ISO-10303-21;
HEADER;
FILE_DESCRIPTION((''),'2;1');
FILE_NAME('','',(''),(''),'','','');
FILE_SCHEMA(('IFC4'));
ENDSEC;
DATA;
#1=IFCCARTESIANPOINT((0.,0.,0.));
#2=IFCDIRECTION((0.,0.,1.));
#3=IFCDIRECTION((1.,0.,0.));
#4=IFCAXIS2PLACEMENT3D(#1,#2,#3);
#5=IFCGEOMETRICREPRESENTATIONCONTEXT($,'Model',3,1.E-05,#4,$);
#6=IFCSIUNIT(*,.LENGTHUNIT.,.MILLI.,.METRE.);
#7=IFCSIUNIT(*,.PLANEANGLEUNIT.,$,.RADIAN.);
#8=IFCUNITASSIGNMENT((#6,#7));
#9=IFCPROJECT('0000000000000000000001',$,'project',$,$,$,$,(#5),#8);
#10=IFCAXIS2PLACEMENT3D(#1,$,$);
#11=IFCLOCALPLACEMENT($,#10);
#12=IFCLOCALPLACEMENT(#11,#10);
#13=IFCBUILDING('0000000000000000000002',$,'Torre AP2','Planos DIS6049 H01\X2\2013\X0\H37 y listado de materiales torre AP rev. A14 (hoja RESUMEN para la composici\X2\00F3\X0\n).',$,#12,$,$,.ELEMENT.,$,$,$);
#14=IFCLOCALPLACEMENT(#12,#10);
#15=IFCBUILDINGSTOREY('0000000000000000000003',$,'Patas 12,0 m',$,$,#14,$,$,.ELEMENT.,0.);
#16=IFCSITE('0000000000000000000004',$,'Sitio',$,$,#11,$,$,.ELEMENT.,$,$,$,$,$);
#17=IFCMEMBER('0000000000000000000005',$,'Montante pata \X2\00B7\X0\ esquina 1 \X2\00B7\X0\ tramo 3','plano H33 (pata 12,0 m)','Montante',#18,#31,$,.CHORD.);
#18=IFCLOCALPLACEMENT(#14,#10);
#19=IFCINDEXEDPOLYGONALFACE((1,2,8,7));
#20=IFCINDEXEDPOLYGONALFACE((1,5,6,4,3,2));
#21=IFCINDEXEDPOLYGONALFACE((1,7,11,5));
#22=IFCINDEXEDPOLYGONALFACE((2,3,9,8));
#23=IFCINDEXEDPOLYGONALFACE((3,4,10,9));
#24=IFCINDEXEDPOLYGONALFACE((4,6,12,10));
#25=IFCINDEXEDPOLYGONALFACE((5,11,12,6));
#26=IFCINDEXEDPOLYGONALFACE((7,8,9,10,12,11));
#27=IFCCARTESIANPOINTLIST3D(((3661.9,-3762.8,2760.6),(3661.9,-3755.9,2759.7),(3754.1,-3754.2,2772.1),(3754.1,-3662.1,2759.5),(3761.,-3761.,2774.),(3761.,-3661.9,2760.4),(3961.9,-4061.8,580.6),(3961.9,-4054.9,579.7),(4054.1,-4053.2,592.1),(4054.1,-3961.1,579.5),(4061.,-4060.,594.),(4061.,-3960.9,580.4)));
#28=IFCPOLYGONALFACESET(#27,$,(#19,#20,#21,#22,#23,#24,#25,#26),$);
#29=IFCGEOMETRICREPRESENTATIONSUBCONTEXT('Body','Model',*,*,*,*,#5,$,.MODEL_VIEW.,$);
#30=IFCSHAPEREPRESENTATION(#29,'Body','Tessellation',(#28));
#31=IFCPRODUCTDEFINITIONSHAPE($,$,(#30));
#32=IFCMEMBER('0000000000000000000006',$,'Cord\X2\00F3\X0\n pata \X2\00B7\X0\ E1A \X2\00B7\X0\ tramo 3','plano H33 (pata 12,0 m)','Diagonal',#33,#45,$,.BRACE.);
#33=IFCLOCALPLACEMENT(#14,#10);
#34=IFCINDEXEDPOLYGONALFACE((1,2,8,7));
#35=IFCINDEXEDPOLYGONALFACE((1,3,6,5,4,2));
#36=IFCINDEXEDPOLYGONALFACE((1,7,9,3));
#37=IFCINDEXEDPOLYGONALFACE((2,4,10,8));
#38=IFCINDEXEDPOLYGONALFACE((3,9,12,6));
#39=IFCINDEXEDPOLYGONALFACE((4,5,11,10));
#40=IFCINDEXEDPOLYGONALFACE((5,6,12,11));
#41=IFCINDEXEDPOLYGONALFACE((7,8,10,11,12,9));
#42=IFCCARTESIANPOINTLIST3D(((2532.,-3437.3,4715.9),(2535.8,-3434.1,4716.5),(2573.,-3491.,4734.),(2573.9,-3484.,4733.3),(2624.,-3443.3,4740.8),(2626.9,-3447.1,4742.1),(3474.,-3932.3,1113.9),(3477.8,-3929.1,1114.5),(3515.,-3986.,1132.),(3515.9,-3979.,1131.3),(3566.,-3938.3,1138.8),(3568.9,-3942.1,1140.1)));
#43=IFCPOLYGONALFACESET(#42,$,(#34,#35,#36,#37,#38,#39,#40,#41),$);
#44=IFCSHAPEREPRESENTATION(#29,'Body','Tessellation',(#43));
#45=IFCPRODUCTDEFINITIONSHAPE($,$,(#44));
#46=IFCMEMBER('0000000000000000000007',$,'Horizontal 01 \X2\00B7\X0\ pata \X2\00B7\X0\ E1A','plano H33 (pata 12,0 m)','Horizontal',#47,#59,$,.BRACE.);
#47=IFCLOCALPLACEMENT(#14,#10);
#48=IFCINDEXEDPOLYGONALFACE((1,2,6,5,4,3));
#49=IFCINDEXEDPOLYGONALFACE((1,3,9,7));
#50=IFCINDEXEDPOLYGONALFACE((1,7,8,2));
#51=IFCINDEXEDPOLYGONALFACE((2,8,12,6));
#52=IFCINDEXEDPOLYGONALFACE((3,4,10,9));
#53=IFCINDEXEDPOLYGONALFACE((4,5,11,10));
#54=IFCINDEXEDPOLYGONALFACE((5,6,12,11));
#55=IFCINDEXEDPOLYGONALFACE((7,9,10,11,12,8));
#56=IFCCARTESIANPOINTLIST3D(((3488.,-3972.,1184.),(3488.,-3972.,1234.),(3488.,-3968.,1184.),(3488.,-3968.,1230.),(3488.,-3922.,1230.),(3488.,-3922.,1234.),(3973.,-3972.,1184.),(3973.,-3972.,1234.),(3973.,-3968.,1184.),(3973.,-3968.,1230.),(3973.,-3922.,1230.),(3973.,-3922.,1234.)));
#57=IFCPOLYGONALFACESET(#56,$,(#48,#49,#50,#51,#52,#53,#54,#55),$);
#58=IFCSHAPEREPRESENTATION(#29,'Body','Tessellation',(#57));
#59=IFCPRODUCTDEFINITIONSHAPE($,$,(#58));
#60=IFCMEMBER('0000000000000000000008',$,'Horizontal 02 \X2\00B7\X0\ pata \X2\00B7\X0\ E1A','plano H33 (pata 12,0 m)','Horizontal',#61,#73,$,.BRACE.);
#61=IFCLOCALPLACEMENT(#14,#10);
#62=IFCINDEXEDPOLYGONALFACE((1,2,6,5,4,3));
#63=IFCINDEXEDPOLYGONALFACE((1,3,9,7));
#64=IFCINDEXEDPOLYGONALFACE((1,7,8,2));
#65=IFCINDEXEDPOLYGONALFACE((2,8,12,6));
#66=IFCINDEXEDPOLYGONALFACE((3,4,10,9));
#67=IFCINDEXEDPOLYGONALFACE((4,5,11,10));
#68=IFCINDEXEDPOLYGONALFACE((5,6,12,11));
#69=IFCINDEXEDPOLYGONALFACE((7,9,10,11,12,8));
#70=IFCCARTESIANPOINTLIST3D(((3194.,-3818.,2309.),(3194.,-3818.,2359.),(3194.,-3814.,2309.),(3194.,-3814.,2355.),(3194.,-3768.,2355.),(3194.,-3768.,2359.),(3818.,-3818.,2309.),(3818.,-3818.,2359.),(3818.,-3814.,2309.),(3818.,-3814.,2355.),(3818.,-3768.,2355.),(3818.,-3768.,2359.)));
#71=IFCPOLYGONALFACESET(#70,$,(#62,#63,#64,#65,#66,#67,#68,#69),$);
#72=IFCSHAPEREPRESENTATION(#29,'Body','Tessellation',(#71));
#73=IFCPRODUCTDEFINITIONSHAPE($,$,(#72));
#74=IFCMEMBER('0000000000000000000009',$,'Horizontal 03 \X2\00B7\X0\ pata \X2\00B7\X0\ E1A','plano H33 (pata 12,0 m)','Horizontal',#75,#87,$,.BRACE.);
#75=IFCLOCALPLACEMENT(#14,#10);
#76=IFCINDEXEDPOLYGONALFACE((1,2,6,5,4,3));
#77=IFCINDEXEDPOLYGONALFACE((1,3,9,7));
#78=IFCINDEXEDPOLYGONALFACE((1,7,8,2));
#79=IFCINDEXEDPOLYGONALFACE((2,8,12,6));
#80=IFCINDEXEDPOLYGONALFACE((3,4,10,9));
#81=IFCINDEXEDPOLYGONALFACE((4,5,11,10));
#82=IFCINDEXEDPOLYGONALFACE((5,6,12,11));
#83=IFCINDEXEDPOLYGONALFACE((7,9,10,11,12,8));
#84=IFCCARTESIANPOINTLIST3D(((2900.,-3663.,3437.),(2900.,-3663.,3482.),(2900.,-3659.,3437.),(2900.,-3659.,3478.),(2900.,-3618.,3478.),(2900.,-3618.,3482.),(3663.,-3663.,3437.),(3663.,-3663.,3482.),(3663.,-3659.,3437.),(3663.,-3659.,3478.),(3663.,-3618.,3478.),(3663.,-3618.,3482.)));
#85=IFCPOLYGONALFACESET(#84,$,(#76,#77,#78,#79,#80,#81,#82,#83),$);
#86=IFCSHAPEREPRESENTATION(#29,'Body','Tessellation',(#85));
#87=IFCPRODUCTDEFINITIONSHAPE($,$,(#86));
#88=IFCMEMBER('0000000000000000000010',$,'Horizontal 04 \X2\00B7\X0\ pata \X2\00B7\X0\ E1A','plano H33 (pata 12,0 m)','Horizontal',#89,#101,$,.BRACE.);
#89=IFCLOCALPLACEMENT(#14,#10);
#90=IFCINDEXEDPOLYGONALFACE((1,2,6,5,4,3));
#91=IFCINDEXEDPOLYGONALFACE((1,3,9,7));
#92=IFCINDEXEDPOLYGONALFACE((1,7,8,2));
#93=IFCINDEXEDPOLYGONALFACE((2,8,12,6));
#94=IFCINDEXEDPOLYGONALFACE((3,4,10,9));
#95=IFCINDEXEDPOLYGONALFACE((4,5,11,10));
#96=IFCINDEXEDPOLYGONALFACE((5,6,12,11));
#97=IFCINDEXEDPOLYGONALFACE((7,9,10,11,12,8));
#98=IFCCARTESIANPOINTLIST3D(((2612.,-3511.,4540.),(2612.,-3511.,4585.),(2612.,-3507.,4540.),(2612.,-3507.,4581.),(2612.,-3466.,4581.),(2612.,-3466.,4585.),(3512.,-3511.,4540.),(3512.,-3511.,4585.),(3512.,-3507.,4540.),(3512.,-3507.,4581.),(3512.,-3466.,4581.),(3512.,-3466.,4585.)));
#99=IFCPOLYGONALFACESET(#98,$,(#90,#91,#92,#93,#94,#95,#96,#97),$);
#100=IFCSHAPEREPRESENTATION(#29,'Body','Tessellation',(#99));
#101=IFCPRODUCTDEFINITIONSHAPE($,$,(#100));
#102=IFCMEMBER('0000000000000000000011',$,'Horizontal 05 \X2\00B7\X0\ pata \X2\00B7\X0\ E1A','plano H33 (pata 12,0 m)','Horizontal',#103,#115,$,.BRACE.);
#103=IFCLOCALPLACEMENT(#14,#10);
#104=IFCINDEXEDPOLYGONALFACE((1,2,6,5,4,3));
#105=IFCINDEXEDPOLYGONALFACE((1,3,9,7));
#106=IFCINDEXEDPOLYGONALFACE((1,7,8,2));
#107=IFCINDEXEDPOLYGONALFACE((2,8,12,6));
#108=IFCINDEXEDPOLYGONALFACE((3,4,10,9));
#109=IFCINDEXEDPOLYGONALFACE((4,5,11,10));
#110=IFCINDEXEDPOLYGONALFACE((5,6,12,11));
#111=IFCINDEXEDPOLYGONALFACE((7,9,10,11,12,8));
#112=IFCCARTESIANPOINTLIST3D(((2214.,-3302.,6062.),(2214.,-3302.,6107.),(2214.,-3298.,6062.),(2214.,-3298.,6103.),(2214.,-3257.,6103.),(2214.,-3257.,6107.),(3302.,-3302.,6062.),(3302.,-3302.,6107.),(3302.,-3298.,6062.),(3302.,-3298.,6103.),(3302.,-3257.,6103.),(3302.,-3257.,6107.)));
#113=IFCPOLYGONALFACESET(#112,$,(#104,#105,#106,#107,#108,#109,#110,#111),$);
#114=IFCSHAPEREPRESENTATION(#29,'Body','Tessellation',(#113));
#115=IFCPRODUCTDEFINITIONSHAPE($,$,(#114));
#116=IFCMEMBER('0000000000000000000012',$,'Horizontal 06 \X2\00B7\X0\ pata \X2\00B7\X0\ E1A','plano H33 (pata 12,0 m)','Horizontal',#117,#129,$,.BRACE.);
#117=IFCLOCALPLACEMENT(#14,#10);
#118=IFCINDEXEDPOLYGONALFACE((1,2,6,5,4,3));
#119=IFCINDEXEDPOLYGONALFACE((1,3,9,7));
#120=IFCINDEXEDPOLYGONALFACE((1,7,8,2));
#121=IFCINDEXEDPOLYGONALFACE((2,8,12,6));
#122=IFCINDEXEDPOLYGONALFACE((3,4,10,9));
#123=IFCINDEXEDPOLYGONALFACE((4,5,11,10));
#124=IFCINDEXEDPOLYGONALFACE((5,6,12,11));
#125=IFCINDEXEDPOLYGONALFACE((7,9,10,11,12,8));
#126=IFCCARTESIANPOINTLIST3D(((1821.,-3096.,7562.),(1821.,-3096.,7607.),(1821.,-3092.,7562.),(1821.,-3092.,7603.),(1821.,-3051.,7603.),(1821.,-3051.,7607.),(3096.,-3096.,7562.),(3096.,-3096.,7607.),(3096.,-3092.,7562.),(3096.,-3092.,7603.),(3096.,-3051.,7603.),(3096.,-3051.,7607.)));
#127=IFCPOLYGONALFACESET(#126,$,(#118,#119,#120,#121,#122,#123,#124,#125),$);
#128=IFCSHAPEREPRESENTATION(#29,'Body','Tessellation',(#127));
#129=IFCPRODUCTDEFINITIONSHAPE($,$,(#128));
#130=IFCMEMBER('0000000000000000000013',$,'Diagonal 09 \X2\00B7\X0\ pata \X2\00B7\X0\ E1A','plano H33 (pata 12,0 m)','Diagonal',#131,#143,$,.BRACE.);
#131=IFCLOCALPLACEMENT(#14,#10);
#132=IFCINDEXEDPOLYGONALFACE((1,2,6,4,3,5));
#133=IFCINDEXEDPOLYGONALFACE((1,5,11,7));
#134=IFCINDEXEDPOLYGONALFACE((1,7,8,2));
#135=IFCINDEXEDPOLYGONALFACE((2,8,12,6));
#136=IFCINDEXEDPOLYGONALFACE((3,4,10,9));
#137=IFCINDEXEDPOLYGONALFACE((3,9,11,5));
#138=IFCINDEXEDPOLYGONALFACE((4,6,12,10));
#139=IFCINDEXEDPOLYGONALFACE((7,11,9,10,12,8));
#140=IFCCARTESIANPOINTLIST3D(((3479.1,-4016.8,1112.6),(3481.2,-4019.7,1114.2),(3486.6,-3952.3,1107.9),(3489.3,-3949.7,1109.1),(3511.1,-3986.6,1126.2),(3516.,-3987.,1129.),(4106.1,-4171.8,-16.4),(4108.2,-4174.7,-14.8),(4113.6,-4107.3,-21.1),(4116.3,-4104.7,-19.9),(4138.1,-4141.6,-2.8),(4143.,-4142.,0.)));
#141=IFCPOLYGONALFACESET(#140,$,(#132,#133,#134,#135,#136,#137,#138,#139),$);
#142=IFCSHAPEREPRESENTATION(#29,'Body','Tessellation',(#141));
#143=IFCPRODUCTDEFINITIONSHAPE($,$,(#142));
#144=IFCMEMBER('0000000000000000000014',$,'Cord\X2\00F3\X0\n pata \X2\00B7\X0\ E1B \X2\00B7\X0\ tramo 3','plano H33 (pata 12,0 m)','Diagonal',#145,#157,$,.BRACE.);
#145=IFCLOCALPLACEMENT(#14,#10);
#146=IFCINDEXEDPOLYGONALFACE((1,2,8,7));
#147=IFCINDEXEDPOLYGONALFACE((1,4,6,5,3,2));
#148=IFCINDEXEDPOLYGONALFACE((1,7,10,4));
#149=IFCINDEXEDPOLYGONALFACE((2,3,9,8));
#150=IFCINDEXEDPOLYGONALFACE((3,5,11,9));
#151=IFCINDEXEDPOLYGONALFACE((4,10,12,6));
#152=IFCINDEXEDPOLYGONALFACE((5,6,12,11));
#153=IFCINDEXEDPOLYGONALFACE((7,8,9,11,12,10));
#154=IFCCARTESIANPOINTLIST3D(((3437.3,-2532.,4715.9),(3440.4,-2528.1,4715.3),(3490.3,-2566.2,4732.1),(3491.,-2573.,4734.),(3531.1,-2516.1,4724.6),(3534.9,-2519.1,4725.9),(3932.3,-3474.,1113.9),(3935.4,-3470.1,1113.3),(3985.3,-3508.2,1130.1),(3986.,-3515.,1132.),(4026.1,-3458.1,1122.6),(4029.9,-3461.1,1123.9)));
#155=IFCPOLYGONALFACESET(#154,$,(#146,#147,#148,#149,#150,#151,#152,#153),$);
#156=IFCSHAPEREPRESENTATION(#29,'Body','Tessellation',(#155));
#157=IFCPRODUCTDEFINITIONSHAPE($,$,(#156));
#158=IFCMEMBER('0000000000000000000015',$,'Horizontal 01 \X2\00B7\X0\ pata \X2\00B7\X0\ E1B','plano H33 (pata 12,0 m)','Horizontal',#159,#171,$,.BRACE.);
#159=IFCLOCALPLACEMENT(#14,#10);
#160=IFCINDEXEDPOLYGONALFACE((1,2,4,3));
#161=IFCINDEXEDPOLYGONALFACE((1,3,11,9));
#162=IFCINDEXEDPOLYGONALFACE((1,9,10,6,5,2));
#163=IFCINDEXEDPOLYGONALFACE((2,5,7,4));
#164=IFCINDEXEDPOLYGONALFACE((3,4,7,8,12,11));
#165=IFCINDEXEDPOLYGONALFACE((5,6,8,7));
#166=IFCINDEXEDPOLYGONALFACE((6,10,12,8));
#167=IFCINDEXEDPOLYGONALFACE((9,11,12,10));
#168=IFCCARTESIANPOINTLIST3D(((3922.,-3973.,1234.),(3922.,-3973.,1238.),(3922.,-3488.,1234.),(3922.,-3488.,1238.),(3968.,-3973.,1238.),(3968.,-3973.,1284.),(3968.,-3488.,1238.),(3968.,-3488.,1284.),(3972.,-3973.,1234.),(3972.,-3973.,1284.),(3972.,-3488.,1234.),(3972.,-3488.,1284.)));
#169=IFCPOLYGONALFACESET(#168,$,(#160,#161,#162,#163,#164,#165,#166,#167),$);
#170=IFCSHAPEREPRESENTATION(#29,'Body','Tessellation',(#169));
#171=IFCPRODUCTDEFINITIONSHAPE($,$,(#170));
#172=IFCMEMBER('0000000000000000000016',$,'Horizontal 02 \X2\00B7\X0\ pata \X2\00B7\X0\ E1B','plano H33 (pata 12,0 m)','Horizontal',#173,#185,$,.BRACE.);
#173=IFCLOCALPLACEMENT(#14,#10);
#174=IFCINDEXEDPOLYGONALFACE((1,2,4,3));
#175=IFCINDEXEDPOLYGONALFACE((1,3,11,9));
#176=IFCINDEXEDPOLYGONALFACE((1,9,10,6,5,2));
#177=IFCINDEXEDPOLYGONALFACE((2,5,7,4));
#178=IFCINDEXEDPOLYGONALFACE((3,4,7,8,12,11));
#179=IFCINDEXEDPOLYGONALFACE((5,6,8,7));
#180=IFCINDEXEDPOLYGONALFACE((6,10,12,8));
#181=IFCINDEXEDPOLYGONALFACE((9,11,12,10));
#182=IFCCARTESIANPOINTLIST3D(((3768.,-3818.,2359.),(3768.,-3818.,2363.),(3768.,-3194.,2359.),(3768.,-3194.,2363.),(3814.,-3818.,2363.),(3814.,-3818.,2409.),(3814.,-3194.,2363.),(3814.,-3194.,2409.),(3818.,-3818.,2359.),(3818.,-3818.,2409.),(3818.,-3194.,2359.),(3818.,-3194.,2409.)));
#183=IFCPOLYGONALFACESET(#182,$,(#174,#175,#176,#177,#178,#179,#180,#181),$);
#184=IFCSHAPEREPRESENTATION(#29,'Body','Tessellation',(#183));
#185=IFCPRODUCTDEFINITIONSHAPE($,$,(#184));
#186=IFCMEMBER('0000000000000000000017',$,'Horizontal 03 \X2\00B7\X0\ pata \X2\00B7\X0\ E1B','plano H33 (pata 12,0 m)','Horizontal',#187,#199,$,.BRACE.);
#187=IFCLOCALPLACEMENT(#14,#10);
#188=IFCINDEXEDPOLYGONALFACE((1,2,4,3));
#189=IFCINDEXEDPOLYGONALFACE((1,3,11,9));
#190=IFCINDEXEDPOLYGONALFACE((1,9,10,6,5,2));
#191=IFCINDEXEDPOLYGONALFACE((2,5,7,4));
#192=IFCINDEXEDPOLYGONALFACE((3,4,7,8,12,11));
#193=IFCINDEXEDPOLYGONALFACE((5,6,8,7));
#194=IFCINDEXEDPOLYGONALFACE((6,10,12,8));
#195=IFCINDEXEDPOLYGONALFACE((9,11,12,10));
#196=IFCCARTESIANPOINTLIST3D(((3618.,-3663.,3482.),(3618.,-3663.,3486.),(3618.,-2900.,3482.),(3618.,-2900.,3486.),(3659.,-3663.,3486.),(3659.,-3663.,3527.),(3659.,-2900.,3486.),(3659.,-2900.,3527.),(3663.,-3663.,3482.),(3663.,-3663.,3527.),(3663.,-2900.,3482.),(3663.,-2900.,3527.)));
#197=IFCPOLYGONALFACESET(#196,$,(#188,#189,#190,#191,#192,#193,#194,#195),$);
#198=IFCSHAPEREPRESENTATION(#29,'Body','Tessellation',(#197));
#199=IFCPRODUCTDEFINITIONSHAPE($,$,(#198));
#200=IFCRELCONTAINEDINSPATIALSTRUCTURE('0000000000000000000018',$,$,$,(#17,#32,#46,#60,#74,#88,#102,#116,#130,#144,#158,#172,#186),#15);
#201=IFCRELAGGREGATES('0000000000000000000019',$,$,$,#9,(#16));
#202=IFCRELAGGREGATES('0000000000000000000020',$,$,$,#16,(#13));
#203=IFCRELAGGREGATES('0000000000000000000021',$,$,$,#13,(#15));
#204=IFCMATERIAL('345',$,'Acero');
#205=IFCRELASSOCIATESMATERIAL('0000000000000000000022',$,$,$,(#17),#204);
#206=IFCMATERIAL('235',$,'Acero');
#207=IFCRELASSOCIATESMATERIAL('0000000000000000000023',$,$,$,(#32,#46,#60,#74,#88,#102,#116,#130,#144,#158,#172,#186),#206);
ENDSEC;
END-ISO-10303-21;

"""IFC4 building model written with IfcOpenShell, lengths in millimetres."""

from ifc_helpers import new_model, si_unit, frame, frame_2d, origin, origin_with_axes, place, context, subcontext, project, spatial, l_section, extrude, material, element, save


model = new_model("IFC4")

# Units and contexts
model_context = context("Model", 3, precision=1e-05, world=origin_with_axes())
body_context = subcontext(model_context, "Body", "Model", "MODEL_VIEW")
ifc_project = project(units=[si_unit("LENGTHUNIT", "METRE", prefix="MILLI"), si_unit("PLANEANGLEUNIT", "RADIAN")], contexts=[model_context])

# Site, building, storey
site_placement = place(None, origin())
site = spatial("IfcSite", under=ifc_project, at=site_placement, Name="Sitio", CompositionType="ELEMENT")
building_placement = place(site_placement, origin())
building = spatial("IfcBuilding", under=site, at=building_placement, Name="Torre AP2", Description="Planos DIS6049 H01–H37 y listado de materiales torre AP rev. A14 (hoja RESUMEN para la composición).", CompositionType="ELEMENT")
storey_placement = place(building_placement, origin())
storey = spatial("IfcBuildingStorey", under=building, at=storey_placement, Name="Patas 12,0 m", CompositionType="ELEMENT", Elevation=0.0)

# Members
ifc_material_1 = material(Name="345", Category="Acero")
member_1_placement = place(storey_placement, frame((3761.0, -3761.0, 2774.0), z_axis=(0.135089, -0.134638, -0.981643), x_axis=(-0.990834, -0.018356, -0.133836)))
element("IfcMember", 1, at=member_1_placement, inside=storey, material=ifc_material_1, Name="Montante pata · esquina 1 · tramo 3", Description="plano H33 (pata 12,0 m)", ObjectType="Montante", PredefinedType="CHORD", context=body_context, shape_type="SweptSolid", body=[
    extrude(l_section(Depth=100.0, Width=100.0, Thickness=7.0, at=frame_2d((50.0, 50.0))), None, (0.0, 0.0, 1.0), 2220.8),
])
ifc_material_2 = material(Name="235", Category="Acero")
member_2_placement = place(storey_placement, frame((2573.0, -3491.0, 4734.0), z_axis=(0.250805, -0.131793, -0.959024), x_axis=(-0.586303, 0.767633, -0.258822)))
element("IfcMember", 2, at=member_2_placement, inside=storey, material=ifc_material_2, Name="Cordón pata · E1A · tramo 3", Description="plano H33 (pata 12,0 m)", ObjectType="Diagonal", PredefinedType="BRACE", context=body_context, shape_type="SweptSolid", body=[
    extrude(l_section(Depth=70.0, Width=70.0, Thickness=5.0, at=frame_2d((35.0, 35.0))), None, (0.0, 0.0, 1.0), 3755.9),
])
member_3_placement = place(storey_placement, frame((3973.0, -3972.0, 1234.0), z_axis=(-1.0, 0.0, 0.0), x_axis=(0.0, 1.0, 0.0)))
element("IfcMember", 3, at=member_3_placement, inside=storey, material=ifc_material_2, Name="Horizontal 01 · pata · E1A", Description="plano H33 (pata 12,0 m)", ObjectType="Horizontal", PredefinedType="BRACE", context=body_context, shape_type="SweptSolid", body=[
    extrude(l_section(Depth=50.0, Width=50.0, Thickness=4.0, at=frame_2d((25.0, 25.0))), None, (0.0, 0.0, 1.0), 485.0),
])
member_4_placement = place(storey_placement, frame((3818.0, -3818.0, 2359.0), z_axis=(-1.0, 0.0, 0.0), x_axis=(0.0, 1.0, 0.0)))
element("IfcMember", 4, at=member_4_placement, inside=storey, material=ifc_material_2, Name="Horizontal 02 · pata · E1A", Description="plano H33 (pata 12,0 m)", ObjectType="Horizontal", PredefinedType="BRACE", context=body_context, shape_type="SweptSolid", body=[
    extrude(l_section(Depth=50.0, Width=50.0, Thickness=4.0, at=frame_2d((25.0, 25.0))), None, (0.0, 0.0, 1.0), 624.0),
])
member_5_placement = place(storey_placement, frame((3663.0, -3663.0, 3482.0), z_axis=(-1.0, 0.0, 0.0), x_axis=(0.0, 1.0, 0.0)))
element("IfcMember", 5, at=member_5_placement, inside=storey, material=ifc_material_2, Name="Horizontal 03 · pata · E1A", Description="plano H33 (pata 12,0 m)", ObjectType="Horizontal", PredefinedType="BRACE", context=body_context, shape_type="SweptSolid", body=[
    extrude(l_section(Depth=45.0, Width=45.0, Thickness=4.0, at=frame_2d((22.5, 22.5))), None, (0.0, 0.0, 1.0), 763.0),
])
member_6_placement = place(storey_placement, frame((3512.0, -3511.0, 4585.0), z_axis=(-1.0, 0.0, 0.0), x_axis=(0.0, 1.0, 0.0)))
element("IfcMember", 6, at=member_6_placement, inside=storey, material=ifc_material_2, Name="Horizontal 04 · pata · E1A", Description="plano H33 (pata 12,0 m)", ObjectType="Horizontal", PredefinedType="BRACE", context=body_context, shape_type="SweptSolid", body=[
    extrude(l_section(Depth=45.0, Width=45.0, Thickness=4.0, at=frame_2d((22.5, 22.5))), None, (0.0, 0.0, 1.0), 900.0),
])
member_7_placement = place(storey_placement, frame((3302.0, -3302.0, 6107.0), z_axis=(-1.0, 0.0, 0.0), x_axis=(0.0, 1.0, 0.0)))
element("IfcMember", 7, at=member_7_placement, inside=storey, material=ifc_material_2, Name="Horizontal 05 · pata · E1A", Description="plano H33 (pata 12,0 m)", ObjectType="Horizontal", PredefinedType="BRACE", context=body_context, shape_type="SweptSolid", body=[
    extrude(l_section(Depth=45.0, Width=45.0, Thickness=4.0, at=frame_2d((22.5, 22.5))), None, (0.0, 0.0, 1.0), 1088.0),
])
member_8_placement = place(storey_placement, frame((3096.0, -3096.0, 7607.0), z_axis=(-1.0, 0.0, 0.0), x_axis=(0.0, 1.0, 0.0)))
element("IfcMember", 8, at=member_8_placement, inside=storey, material=ifc_material_2, Name="Horizontal 06 · pata · E1A", Description="plano H33 (pata 12,0 m)", ObjectType="Horizontal", PredefinedType="BRACE", context=body_context, shape_type="SweptSolid", body=[
    extrude(l_section(Depth=45.0, Width=45.0, Thickness=4.0, at=frame_2d((22.5, 22.5))), None, (0.0, 0.0, 1.0), 1275.0),
])
member_9_placement = place(storey_placement, frame((4143.0, -4142.0, 0.0), z_axis=(-0.482052, 0.119168, 0.868001), x_axis=(-0.53324, 0.746182, -0.398583)))
element("IfcMember", 9, at=member_9_placement, inside=storey, material=ifc_material_2, Name="Diagonal 09 · pata · E1A", Description="plano H33 (pata 12,0 m)", ObjectType="Diagonal", PredefinedType="BRACE", context=body_context, shape_type="SweptSolid", body=[
    extrude(l_section(Depth=50.0, Width=50.0, Thickness=4.0, at=frame_2d((25.0, 25.0))), None, (0.0, 0.0, 1.0), 1300.7),
])
member_10_placement = place(storey_placement, frame((3491.0, -2573.0, 4734.0), z_axis=(0.131793, -0.250805, -0.959024), x_axis=(-0.767633, 0.586303, -0.258822)))
element("IfcMember", 10, at=member_10_placement, inside=storey, material=ifc_material_2, Name="Cordón pata · E1B · tramo 3", Description="plano H33 (pata 12,0 m)", ObjectType="Diagonal", PredefinedType="BRACE", context=body_context, shape_type="SweptSolid", body=[
    extrude(l_section(Depth=70.0, Width=70.0, Thickness=5.0, at=frame_2d((35.0, 35.0))), None, (0.0, 0.0, 1.0), 3755.9),
])
member_11_placement = place(storey_placement, frame((3972.0, -3973.0, 1234.0), z_axis=(0.0, 1.0, 0.0), x_axis=(-1.0, 0.0, 0.0)))
element("IfcMember", 11, at=member_11_placement, inside=storey, material=ifc_material_2, Name="Horizontal 01 · pata · E1B", Description="plano H33 (pata 12,0 m)", ObjectType="Horizontal", PredefinedType="BRACE", context=body_context, shape_type="SweptSolid", body=[
    extrude(l_section(Depth=50.0, Width=50.0, Thickness=4.0, at=frame_2d((25.0, 25.0))), None, (0.0, 0.0, 1.0), 485.0),
])
member_12_placement = place(storey_placement, frame((3818.0, -3818.0, 2359.0), z_axis=(0.0, 1.0, 0.0), x_axis=(-1.0, 0.0, 0.0)))
element("IfcMember", 12, at=member_12_placement, inside=storey, material=ifc_material_2, Name="Horizontal 02 · pata · E1B", Description="plano H33 (pata 12,0 m)", ObjectType="Horizontal", PredefinedType="BRACE", context=body_context, shape_type="SweptSolid", body=[
    extrude(l_section(Depth=50.0, Width=50.0, Thickness=4.0, at=frame_2d((25.0, 25.0))), None, (0.0, 0.0, 1.0), 624.0),
])
member_13_placement = place(storey_placement, frame((3663.0, -3663.0, 3482.0), z_axis=(0.0, 1.0, 0.0), x_axis=(-1.0, 0.0, 0.0)))
element("IfcMember", 13, at=member_13_placement, inside=storey, material=ifc_material_2, Name="Horizontal 03 · pata · E1B", Description="plano H33 (pata 12,0 m)", ObjectType="Horizontal", PredefinedType="BRACE", context=body_context, shape_type="SweptSolid", body=[
    extrude(l_section(Depth=45.0, Width=45.0, Thickness=4.0, at=frame_2d((22.5, 22.5))), None, (0.0, 0.0, 1.0), 763.0),
])

save(model, "model.ifc")
